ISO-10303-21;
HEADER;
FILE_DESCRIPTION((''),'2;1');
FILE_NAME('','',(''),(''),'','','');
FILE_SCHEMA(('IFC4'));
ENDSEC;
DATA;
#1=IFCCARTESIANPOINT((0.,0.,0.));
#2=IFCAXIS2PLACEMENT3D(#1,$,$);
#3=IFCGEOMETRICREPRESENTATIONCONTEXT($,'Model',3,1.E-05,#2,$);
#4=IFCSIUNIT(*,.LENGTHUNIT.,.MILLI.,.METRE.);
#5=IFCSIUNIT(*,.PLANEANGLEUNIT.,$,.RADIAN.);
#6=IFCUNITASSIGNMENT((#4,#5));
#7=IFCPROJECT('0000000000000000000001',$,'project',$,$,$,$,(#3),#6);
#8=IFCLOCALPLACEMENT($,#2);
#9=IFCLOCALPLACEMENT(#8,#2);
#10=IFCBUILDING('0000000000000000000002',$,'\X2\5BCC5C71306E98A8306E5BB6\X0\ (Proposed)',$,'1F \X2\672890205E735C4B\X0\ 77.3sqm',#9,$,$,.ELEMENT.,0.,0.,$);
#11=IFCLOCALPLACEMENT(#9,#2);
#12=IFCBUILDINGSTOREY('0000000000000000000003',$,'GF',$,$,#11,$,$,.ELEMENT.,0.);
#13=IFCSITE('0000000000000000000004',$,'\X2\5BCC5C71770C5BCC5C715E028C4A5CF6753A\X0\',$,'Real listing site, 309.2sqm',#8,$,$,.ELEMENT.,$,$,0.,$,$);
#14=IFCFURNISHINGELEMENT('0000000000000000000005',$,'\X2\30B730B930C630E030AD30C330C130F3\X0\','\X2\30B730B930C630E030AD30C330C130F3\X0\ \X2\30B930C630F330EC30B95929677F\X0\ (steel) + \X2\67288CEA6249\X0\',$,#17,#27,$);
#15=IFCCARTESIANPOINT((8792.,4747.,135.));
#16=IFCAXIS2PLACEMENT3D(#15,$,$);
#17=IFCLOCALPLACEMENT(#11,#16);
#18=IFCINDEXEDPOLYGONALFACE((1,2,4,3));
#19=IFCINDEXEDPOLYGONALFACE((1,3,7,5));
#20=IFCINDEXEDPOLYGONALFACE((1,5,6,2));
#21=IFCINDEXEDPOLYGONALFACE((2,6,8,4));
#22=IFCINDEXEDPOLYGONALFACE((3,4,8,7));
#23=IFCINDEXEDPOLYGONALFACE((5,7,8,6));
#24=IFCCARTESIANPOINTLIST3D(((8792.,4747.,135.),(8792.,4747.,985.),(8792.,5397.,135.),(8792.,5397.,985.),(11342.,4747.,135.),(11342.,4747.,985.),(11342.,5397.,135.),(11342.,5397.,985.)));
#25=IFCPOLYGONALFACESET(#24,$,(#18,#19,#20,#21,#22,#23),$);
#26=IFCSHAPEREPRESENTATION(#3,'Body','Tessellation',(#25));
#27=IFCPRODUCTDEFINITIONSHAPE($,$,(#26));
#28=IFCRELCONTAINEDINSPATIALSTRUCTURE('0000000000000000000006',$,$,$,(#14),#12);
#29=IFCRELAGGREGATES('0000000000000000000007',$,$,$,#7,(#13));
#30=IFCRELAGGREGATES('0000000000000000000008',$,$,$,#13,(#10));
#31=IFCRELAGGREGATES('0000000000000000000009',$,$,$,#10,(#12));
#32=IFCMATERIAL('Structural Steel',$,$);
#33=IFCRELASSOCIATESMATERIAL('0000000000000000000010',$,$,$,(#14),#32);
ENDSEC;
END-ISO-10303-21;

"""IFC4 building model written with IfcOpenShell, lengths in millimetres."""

from ifc_helpers import new_model, si_unit, frame, frame_2d, origin, place, context, project, spatial, rectangle, extrude, material, element, save


model = new_model("IFC4")

# Units and contexts
model_context = context("Model", 3, precision=1e-05, world=origin())
ifc_project = project(units=[si_unit("LENGTHUNIT", "METRE", prefix="MILLI"), si_unit("PLANEANGLEUNIT", "RADIAN")], contexts=[model_context])

# Site, building, storey
site_placement = place(None, origin())
site = spatial("IfcSite", under=ifc_project, at=site_placement, Name="富山県富山市豊島町", ObjectType="Real listing site, 309.2sqm", CompositionType="ELEMENT", RefElevation=0.0)
building_placement = place(site_placement, origin())
building = spatial("IfcBuilding", under=site, at=building_placement, Name="富山の風の家 (Proposed)", ObjectType="1F 木造平屋 77.3sqm", CompositionType="ELEMENT", ElevationOfRefHeight=0.0, ElevationOfTerrain=0.0)
storey_placement = place(building_placement, origin())
storey = spatial("IfcBuildingStorey", under=building, at=storey_placement, Name="GF", CompositionType="ELEMENT", Elevation=0.0)

# Furnishing element
ifc_material_1 = material(Name="Structural Steel")
furnishing_1_placement = place(storey_placement, frame((8792.0, 4747.0, 135.0)))
element("IfcFurnishingElement", 1, at=furnishing_1_placement, inside=storey, material=ifc_material_1, Name="システムキッチン", Description="システムキッチン ステンレス天板 (steel) + 木質扉", context=model_context, shape_type="SweptSolid", body=[
    extrude(rectangle(XDim=2550.0, YDim=650.0, at=frame_2d((1275.0, 325.0))), frame((8792.0, 4747.0, 135.0)), (0.0, 0.0, 1.0), 850.0),
])

save(model, "model.ifc")
